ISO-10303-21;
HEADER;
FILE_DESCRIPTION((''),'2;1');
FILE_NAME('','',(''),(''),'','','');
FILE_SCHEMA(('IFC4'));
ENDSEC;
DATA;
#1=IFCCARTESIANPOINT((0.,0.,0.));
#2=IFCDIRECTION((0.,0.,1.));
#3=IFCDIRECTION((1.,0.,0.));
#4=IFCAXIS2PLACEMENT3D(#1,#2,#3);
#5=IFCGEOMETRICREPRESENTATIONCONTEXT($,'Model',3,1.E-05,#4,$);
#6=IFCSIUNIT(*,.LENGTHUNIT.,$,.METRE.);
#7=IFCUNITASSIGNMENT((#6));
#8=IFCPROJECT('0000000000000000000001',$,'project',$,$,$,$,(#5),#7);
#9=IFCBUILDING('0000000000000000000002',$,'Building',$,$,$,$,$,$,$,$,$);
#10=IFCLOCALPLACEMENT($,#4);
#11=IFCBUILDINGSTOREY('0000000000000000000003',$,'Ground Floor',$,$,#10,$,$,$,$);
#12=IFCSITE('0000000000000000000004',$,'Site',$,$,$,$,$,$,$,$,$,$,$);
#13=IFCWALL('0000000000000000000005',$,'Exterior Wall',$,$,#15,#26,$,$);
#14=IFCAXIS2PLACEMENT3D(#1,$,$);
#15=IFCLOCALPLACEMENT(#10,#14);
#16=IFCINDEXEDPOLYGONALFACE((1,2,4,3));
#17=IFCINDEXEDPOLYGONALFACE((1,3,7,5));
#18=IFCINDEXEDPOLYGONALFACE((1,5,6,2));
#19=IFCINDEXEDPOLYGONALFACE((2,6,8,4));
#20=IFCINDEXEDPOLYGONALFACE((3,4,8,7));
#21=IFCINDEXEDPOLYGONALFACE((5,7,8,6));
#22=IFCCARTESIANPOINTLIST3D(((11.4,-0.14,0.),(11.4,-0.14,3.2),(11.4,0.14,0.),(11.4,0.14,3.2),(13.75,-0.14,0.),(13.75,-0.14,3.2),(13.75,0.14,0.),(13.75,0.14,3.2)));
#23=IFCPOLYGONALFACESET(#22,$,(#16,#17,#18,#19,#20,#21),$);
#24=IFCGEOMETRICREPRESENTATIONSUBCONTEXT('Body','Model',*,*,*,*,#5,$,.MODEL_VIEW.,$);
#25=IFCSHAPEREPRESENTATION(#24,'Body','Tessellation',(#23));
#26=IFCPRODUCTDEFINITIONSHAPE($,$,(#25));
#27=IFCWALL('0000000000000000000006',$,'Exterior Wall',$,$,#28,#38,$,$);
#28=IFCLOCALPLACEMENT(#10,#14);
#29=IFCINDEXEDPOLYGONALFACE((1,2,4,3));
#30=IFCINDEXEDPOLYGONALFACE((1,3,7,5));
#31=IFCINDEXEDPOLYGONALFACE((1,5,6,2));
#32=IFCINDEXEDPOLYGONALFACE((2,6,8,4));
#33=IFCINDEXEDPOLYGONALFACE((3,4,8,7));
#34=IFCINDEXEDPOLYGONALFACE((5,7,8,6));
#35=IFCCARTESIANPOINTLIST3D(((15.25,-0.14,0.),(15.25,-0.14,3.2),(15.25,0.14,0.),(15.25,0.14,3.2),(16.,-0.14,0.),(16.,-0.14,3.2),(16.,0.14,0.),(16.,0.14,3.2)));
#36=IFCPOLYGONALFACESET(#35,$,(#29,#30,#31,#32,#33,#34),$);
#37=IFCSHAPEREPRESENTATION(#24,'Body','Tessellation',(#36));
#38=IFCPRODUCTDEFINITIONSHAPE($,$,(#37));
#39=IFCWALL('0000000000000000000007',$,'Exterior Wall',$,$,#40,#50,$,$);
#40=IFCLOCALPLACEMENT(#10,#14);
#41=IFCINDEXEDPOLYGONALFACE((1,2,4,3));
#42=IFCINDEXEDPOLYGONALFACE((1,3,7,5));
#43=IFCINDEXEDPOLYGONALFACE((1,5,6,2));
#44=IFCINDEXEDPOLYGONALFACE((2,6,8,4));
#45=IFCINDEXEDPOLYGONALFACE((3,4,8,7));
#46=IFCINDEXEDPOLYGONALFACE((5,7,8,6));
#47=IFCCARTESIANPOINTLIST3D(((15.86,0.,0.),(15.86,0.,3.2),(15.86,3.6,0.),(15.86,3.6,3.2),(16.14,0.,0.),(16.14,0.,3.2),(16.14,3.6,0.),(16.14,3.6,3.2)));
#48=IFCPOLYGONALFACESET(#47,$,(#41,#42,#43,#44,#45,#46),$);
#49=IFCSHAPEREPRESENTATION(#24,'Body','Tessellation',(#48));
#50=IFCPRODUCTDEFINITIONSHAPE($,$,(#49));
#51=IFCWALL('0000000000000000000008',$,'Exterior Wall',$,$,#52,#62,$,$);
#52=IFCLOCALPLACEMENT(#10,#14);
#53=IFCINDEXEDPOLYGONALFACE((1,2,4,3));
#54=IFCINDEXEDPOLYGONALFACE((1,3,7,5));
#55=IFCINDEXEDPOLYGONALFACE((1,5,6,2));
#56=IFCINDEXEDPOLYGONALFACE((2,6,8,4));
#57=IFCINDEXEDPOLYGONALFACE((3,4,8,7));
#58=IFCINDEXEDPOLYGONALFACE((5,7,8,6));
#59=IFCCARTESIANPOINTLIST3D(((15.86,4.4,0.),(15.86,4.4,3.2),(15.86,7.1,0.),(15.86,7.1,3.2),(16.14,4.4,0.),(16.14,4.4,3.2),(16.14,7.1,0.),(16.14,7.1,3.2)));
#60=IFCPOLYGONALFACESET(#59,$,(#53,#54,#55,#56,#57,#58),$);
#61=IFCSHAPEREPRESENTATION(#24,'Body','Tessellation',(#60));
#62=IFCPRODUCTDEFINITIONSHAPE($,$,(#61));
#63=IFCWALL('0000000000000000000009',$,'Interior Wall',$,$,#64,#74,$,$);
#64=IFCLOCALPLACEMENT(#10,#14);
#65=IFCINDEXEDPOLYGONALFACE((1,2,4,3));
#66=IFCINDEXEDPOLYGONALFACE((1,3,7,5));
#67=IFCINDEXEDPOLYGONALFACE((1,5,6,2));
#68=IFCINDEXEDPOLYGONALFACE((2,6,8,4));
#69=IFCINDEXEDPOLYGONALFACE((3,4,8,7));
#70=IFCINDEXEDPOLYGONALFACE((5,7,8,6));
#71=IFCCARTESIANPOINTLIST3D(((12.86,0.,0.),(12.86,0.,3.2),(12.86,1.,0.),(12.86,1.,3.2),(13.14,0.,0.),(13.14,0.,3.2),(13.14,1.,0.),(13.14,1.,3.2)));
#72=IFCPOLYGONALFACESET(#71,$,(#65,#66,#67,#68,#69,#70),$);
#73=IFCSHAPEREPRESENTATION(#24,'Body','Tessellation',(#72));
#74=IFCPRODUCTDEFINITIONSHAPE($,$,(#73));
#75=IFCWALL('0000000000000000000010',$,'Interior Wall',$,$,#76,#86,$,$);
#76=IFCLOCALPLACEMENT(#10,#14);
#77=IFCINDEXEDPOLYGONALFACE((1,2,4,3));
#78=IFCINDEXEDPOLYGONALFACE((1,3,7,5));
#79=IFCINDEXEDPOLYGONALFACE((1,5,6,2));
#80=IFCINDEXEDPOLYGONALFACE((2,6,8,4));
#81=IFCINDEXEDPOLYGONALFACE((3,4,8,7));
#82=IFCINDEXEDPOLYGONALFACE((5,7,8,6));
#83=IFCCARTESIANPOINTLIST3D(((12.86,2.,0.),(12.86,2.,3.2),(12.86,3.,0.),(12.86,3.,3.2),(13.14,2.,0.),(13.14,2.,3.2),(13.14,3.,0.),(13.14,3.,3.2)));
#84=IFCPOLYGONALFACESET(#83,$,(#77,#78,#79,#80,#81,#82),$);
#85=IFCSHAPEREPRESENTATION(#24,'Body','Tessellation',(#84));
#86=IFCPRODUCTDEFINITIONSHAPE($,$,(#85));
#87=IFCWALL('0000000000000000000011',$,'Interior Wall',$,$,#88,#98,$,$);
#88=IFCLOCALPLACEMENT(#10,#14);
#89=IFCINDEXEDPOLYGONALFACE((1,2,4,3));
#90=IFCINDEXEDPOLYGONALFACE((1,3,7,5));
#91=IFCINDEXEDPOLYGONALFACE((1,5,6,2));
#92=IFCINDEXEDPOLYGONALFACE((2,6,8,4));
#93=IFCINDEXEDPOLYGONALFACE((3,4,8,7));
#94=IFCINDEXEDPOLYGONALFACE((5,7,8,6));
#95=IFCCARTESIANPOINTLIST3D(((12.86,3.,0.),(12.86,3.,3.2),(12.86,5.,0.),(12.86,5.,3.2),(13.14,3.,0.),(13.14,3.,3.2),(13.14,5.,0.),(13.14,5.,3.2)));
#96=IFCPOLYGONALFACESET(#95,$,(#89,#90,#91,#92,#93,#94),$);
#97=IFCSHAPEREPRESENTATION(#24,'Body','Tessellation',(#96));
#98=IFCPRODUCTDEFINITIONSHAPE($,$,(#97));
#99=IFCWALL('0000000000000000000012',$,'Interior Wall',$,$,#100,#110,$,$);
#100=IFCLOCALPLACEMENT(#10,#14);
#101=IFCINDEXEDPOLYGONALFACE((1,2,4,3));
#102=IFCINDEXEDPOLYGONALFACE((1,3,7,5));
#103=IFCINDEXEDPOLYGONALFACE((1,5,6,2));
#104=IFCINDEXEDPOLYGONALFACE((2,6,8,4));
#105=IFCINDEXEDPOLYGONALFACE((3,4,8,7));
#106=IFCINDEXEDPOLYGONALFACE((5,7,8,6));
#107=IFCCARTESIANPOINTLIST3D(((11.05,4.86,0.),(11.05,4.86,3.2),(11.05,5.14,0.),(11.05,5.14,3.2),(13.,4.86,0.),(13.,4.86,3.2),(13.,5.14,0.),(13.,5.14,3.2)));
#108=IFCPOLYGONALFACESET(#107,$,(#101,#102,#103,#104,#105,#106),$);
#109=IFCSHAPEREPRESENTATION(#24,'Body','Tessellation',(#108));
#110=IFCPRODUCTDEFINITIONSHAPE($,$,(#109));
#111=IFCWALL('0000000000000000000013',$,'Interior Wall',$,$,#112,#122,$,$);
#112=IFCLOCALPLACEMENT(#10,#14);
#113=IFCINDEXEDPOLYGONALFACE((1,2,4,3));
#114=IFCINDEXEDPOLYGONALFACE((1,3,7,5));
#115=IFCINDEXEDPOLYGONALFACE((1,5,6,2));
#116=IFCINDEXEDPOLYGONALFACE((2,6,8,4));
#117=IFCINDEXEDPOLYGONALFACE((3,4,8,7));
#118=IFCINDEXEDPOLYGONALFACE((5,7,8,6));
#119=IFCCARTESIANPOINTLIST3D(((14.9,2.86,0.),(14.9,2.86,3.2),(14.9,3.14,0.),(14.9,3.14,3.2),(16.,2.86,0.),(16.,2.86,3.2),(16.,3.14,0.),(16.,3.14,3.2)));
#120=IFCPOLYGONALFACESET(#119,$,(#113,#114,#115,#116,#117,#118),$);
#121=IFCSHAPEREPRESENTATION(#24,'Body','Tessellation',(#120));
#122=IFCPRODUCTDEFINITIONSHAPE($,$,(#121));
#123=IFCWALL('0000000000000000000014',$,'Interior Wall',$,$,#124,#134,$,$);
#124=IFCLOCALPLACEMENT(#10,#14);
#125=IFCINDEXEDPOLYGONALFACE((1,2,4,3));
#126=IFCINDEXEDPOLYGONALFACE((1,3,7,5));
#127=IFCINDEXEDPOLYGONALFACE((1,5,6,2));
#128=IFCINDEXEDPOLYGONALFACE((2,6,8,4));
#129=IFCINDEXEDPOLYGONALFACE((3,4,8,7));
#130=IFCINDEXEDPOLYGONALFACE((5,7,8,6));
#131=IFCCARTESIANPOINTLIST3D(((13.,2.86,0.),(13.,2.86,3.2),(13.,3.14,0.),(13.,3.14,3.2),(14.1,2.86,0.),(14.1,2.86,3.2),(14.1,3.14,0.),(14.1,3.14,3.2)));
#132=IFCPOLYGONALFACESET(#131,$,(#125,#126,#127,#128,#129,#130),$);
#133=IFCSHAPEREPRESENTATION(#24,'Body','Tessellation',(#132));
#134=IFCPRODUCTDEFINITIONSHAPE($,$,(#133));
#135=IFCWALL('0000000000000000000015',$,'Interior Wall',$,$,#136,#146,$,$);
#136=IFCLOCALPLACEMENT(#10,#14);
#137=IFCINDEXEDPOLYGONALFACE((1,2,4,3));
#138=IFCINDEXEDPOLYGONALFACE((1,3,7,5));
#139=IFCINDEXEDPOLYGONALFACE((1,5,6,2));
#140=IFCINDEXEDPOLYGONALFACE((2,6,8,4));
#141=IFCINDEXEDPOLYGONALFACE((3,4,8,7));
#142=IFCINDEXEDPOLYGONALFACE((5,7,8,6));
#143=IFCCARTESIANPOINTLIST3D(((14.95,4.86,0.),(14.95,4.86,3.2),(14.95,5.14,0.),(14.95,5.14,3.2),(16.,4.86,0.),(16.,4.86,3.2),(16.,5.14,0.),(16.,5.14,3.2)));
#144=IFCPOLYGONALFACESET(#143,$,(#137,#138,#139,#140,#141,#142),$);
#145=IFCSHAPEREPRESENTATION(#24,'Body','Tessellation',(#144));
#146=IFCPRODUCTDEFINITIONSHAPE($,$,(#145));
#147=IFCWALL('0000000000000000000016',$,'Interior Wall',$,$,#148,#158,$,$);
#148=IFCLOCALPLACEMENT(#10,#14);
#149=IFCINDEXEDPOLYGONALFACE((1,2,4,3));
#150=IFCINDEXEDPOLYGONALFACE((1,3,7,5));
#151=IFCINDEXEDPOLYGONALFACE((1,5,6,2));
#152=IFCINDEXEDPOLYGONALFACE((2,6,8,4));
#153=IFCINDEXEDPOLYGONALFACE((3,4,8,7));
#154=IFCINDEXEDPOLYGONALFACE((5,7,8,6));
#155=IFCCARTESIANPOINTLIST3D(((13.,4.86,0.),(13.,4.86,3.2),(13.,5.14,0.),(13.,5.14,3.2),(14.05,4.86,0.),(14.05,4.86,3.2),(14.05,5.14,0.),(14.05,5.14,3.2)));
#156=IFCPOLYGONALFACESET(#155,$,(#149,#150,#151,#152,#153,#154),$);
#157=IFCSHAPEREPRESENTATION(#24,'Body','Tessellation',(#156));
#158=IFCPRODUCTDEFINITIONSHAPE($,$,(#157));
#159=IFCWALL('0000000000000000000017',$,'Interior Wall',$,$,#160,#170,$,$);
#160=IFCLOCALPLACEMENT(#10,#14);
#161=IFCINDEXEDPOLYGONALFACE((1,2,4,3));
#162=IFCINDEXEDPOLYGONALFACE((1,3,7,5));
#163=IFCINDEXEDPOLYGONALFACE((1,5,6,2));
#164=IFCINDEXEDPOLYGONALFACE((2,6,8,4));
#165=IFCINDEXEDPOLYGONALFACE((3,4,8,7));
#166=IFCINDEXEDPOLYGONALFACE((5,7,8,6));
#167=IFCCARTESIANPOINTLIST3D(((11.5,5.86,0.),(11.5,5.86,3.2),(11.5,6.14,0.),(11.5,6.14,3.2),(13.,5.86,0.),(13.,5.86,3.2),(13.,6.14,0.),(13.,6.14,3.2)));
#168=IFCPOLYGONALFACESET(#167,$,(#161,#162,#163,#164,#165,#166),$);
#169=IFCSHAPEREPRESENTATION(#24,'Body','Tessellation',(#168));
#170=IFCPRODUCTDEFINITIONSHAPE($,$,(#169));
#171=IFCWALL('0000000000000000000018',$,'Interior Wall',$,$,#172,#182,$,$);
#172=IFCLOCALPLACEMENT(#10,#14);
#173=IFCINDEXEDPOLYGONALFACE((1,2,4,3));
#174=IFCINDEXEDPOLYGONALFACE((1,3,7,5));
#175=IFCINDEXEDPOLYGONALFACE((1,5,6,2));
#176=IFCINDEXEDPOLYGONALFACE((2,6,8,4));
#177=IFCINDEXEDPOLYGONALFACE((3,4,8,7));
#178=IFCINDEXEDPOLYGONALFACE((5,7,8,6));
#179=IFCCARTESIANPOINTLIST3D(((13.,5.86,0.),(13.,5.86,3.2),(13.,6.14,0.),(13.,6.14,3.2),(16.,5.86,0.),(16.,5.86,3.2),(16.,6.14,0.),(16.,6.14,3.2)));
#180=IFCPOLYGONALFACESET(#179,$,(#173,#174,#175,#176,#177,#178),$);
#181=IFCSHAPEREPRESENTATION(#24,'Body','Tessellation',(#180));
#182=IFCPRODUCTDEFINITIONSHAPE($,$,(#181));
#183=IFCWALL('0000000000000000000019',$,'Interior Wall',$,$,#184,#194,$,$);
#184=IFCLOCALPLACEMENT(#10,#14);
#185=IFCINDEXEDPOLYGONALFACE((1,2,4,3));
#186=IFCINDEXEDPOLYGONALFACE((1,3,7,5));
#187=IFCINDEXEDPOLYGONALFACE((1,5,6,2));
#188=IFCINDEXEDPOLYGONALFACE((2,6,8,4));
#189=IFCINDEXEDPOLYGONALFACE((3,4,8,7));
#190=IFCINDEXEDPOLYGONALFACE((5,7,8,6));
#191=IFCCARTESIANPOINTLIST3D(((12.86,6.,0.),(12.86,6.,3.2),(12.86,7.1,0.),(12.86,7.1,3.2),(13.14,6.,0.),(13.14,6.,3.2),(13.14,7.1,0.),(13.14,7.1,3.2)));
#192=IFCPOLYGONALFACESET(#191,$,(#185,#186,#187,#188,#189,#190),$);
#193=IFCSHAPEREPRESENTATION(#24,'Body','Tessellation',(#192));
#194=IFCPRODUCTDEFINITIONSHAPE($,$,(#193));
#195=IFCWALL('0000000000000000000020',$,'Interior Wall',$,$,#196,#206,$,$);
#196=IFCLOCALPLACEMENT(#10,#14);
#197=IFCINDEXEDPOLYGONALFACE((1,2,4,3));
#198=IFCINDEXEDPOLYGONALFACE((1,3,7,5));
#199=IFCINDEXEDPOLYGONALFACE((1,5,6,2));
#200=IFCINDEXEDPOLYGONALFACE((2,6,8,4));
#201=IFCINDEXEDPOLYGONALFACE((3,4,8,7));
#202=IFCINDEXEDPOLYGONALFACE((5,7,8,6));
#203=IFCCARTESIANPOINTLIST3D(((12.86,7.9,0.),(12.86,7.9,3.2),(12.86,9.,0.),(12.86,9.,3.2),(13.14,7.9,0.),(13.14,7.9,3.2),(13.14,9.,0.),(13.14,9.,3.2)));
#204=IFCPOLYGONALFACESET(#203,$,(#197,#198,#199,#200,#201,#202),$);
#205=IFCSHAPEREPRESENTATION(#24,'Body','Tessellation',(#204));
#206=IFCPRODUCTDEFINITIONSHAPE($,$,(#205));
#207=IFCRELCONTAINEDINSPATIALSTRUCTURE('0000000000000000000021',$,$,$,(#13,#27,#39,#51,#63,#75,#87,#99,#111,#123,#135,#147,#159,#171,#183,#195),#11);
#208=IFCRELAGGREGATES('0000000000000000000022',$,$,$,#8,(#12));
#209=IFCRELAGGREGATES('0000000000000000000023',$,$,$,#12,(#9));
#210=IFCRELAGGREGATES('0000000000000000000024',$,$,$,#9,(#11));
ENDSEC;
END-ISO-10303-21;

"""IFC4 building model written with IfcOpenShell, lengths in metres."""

from ifc_helpers import new_model, si_unit, frame, origin_with_axes, place, context, subcontext, project, spatial, indexed_curve, outline, extrude, element, save


model = new_model("IFC4")

# Units and contexts
model_context = context("Model", 3, precision=1e-05, world=origin_with_axes())
body_context = subcontext(model_context, "Body", "Model", "MODEL_VIEW")
ifc_project = project(units=[si_unit("LENGTHUNIT", "METRE")], contexts=[model_context])

# Site, building, storey
site = spatial("IfcSite", under=ifc_project, Name="Site")
building = spatial("IfcBuilding", under=site, Name="Building")
storey_placement = place(None, origin_with_axes())
storey = spatial("IfcBuildingStorey", under=building, at=storey_placement, Name="Ground Floor")

# Walls
wall_1_placement = place(storey_placement, frame((11.4, 0.0, 0.0), z_axis=(0.0, 0.0, 1.0), x_axis=(1.0, 0.0, 0.0)))
element("IfcWall", 1, at=wall_1_placement, inside=storey, Name="Exterior Wall", context=body_context, shape_type="SweptSolid", body=[
    extrude(outline(indexed_curve([(0.0, 0.0), (0.0, 0.28), (2.35, 0.28), (2.35, 0.0), (0.0, 0.0)], self_intersect=False)), frame((0.0, -0.14, 0.0), z_axis=(0.0, 0.0, 1.0), x_axis=(1.0, 0.0, 0.0)), (0.0, 0.0, 1.0), 3.2),
])
wall_2_placement = place(storey_placement, frame((15.25, 0.0, 0.0), z_axis=(0.0, 0.0, 1.0), x_axis=(1.0, 0.0, 0.0)))
element("IfcWall", 2, at=wall_2_placement, inside=storey, Name="Exterior Wall", context=body_context, shape_type="SweptSolid", body=[
    extrude(outline(indexed_curve([(0.0, 0.0), (0.0, 0.28), (0.75, 0.28), (0.75, 0.0), (0.0, 0.0)], self_intersect=False)), frame((0.0, -0.14, 0.0), z_axis=(0.0, 0.0, 1.0), x_axis=(1.0, 0.0, 0.0)), (0.0, 0.0, 1.0), 3.2),
])
wall_3_placement = place(storey_placement, frame((16.0, 0.0, 0.0), z_axis=(0.0, 0.0, 1.0), x_axis=(0.0, 1.0, 0.0)))
element("IfcWall", 3, at=wall_3_placement, inside=storey, Name="Exterior Wall", context=body_context, shape_type="SweptSolid", body=[
    extrude(outline(indexed_curve([(0.0, 0.0), (0.0, 0.28), (3.6, 0.28), (3.6, 0.0), (0.0, 0.0)], self_intersect=False)), frame((0.0, -0.14, 0.0), z_axis=(0.0, 0.0, 1.0), x_axis=(1.0, 0.0, 0.0)), (0.0, 0.0, 1.0), 3.2),
])
wall_4_placement = place(storey_placement, frame((16.0, 4.4, 0.0), z_axis=(0.0, 0.0, 1.0), x_axis=(0.0, 1.0, 0.0)))
element("IfcWall", 4, at=wall_4_placement, inside=storey, Name="Exterior Wall", context=body_context, shape_type="SweptSolid", body=[
    extrude(outline(indexed_curve([(0.0, 0.0), (0.0, 0.28), (2.7, 0.28), (2.7, 0.0), (0.0, 0.0)], self_intersect=False)), frame((0.0, -0.14, 0.0), z_axis=(0.0, 0.0, 1.0), x_axis=(1.0, 0.0, 0.0)), (0.0, 0.0, 1.0), 3.2),
])
for number, where, z_axis, x_axis, name in (
    (5, (13.0, 0.0, 0.0), (0.0, 0.0, 1.0), (0.0, 1.0, 0.0), "Interior Wall"),
    (6, (13.0, 2.0, 0.0), (0.0, 0.0, 1.0), (0.0, 1.0, 0.0), "Interior Wall"),
):
    element("IfcWall", number, at=place(storey_placement, frame(where, z_axis=z_axis, x_axis=x_axis)), inside=storey, Name=name, context=body_context, shape_type="SweptSolid", body=[
        extrude(outline(indexed_curve([(0.0, 0.0), (0.0, 0.28), (1.0, 0.28), (1.0, 0.0), (0.0, 0.0)], self_intersect=False)), frame((0.0, -0.14, 0.0), z_axis=(0.0, 0.0, 1.0), x_axis=(1.0, 0.0, 0.0)), (0.0, 0.0, 1.0), 3.2),
    ])
wall_5_placement = place(storey_placement, frame((13.0, 3.0, 0.0), z_axis=(0.0, 0.0, 1.0), x_axis=(0.0, 1.0, 0.0)))
element("IfcWall", 7, at=wall_5_placement, inside=storey, Name="Interior Wall", context=body_context, shape_type="SweptSolid", body=[
    extrude(outline(indexed_curve([(0.0, 0.0), (0.0, 0.28), (2.0, 0.28), (2.0, 0.0), (0.0, 0.0)], self_intersect=False)), frame((0.0, -0.14, 0.0), z_axis=(0.0, 0.0, 1.0), x_axis=(1.0, 0.0, 0.0)), (0.0, 0.0, 1.0), 3.2),
])
wall_6_placement = place(storey_placement, frame((13.0, 5.0, 0.0), z_axis=(0.0, 0.0, 1.0), x_axis=(-1.0, 0.0, 0.0)))
element("IfcWall", 8, at=wall_6_placement, inside=storey, Name="Interior Wall", context=body_context, shape_type="SweptSolid", body=[
    extrude(outline(indexed_curve([(0.0, 0.0), (0.0, 0.28), (1.95, 0.28), (1.95, 0.0), (0.0, 0.0)], self_intersect=False)), frame((0.0, -0.14, 0.0), z_axis=(0.0, 0.0, 1.0), x_axis=(1.0, 0.0, 0.0)), (0.0, 0.0, 1.0), 3.2),
])
for number, where, z_axis, x_axis, name in (
    (9, (16.0, 3.0, 0.0), (0.0, 0.0, 1.0), (-1.0, 0.0, 0.0), "Interior Wall"),
    (10, (14.1, 3.0, 0.0), (0.0, 0.0, 1.0), (-1.0, 0.0, 0.0), "Interior Wall"),
):
    element("IfcWall", number, at=place(storey_placement, frame(where, z_axis=z_axis, x_axis=x_axis)), inside=storey, Name=name, context=body_context, shape_type="SweptSolid", body=[
        extrude(outline(indexed_curve([(0.0, 0.0), (0.0, 0.28), (1.1, 0.28), (1.1, 0.0), (0.0, 0.0)], self_intersect=False)), frame((0.0, -0.14, 0.0), z_axis=(0.0, 0.0, 1.0), x_axis=(1.0, 0.0, 0.0)), (0.0, 0.0, 1.0), 3.2),
    ])
for number, where, z_axis, x_axis, name in (
    (11, (16.0, 5.0, 0.0), (0.0, 0.0, 1.0), (-1.0, 0.0, 0.0), "Interior Wall"),
    (12, (14.05, 5.0, 0.0), (0.0, 0.0, 1.0), (-1.0, 0.0, 0.0), "Interior Wall"),
):
    element("IfcWall", number, at=place(storey_placement, frame(where, z_axis=z_axis, x_axis=x_axis)), inside=storey, Name=name, context=body_context, shape_type="SweptSolid", body=[
        extrude(outline(indexed_curve([(0.0, 0.0), (0.0, 0.28), (1.05, 0.28), (1.05, 0.0), (0.0, 0.0)], self_intersect=False)), frame((0.0, -0.14, 0.0), z_axis=(0.0, 0.0, 1.0), x_axis=(1.0, 0.0, 0.0)), (0.0, 0.0, 1.0), 3.2),
    ])
wall_7_placement = place(storey_placement, frame((13.0, 6.0, 0.0), z_axis=(0.0, 0.0, 1.0), x_axis=(-1.0, 0.0, 0.0)))
element("IfcWall", 13, at=wall_7_placement, inside=storey, Name="Interior Wall", context=body_context, shape_type="SweptSolid", body=[
    extrude(outline(indexed_curve([(0.0, 0.0), (0.0, 0.28), (1.5, 0.28), (1.5, 0.0), (0.0, 0.0)], self_intersect=False)), frame((0.0, -0.14, 0.0), z_axis=(0.0, 0.0, 1.0), x_axis=(1.0, 0.0, 0.0)), (0.0, 0.0, 1.0), 3.2),
])
wall_8_placement = place(storey_placement, frame((16.0, 6.0, 0.0), z_axis=(0.0, 0.0, 1.0), x_axis=(-1.0, 0.0, 0.0)))
element("IfcWall", 14, at=wall_8_placement, inside=storey, Name="Interior Wall", context=body_context, shape_type="SweptSolid", body=[
    extrude(outline(indexed_curve([(0.0, 0.0), (0.0, 0.28), (3.0, 0.28), (3.0, 0.0), (0.0, 0.0)], self_intersect=False)), frame((0.0, -0.14, 0.0), z_axis=(0.0, 0.0, 1.0), x_axis=(1.0, 0.0, 0.0)), (0.0, 0.0, 1.0), 3.2),
])
for number, where, z_axis, x_axis, name in (
    (15, (13.0, 6.0, 0.0), (0.0, 0.0, 1.0), (0.0, 1.0, 0.0), "Interior Wall"),
    (16, (13.0, 7.9, 0.0), (0.0, 0.0, 1.0), (0.0, 1.0, 0.0), "Interior Wall"),
):
    element("IfcWall", number, at=place(storey_placement, frame(where, z_axis=z_axis, x_axis=x_axis)), inside=storey, Name=name, context=body_context, shape_type="SweptSolid", body=[
        extrude(outline(indexed_curve([(0.0, 0.0), (0.0, 0.28), (1.1, 0.28), (1.1, 0.0), (0.0, 0.0)], self_intersect=False)), frame((0.0, -0.14, 0.0), z_axis=(0.0, 0.0, 1.0), x_axis=(1.0, 0.0, 0.0)), (0.0, 0.0, 1.0), 3.2),
    ])

save(model, "model.ifc")
